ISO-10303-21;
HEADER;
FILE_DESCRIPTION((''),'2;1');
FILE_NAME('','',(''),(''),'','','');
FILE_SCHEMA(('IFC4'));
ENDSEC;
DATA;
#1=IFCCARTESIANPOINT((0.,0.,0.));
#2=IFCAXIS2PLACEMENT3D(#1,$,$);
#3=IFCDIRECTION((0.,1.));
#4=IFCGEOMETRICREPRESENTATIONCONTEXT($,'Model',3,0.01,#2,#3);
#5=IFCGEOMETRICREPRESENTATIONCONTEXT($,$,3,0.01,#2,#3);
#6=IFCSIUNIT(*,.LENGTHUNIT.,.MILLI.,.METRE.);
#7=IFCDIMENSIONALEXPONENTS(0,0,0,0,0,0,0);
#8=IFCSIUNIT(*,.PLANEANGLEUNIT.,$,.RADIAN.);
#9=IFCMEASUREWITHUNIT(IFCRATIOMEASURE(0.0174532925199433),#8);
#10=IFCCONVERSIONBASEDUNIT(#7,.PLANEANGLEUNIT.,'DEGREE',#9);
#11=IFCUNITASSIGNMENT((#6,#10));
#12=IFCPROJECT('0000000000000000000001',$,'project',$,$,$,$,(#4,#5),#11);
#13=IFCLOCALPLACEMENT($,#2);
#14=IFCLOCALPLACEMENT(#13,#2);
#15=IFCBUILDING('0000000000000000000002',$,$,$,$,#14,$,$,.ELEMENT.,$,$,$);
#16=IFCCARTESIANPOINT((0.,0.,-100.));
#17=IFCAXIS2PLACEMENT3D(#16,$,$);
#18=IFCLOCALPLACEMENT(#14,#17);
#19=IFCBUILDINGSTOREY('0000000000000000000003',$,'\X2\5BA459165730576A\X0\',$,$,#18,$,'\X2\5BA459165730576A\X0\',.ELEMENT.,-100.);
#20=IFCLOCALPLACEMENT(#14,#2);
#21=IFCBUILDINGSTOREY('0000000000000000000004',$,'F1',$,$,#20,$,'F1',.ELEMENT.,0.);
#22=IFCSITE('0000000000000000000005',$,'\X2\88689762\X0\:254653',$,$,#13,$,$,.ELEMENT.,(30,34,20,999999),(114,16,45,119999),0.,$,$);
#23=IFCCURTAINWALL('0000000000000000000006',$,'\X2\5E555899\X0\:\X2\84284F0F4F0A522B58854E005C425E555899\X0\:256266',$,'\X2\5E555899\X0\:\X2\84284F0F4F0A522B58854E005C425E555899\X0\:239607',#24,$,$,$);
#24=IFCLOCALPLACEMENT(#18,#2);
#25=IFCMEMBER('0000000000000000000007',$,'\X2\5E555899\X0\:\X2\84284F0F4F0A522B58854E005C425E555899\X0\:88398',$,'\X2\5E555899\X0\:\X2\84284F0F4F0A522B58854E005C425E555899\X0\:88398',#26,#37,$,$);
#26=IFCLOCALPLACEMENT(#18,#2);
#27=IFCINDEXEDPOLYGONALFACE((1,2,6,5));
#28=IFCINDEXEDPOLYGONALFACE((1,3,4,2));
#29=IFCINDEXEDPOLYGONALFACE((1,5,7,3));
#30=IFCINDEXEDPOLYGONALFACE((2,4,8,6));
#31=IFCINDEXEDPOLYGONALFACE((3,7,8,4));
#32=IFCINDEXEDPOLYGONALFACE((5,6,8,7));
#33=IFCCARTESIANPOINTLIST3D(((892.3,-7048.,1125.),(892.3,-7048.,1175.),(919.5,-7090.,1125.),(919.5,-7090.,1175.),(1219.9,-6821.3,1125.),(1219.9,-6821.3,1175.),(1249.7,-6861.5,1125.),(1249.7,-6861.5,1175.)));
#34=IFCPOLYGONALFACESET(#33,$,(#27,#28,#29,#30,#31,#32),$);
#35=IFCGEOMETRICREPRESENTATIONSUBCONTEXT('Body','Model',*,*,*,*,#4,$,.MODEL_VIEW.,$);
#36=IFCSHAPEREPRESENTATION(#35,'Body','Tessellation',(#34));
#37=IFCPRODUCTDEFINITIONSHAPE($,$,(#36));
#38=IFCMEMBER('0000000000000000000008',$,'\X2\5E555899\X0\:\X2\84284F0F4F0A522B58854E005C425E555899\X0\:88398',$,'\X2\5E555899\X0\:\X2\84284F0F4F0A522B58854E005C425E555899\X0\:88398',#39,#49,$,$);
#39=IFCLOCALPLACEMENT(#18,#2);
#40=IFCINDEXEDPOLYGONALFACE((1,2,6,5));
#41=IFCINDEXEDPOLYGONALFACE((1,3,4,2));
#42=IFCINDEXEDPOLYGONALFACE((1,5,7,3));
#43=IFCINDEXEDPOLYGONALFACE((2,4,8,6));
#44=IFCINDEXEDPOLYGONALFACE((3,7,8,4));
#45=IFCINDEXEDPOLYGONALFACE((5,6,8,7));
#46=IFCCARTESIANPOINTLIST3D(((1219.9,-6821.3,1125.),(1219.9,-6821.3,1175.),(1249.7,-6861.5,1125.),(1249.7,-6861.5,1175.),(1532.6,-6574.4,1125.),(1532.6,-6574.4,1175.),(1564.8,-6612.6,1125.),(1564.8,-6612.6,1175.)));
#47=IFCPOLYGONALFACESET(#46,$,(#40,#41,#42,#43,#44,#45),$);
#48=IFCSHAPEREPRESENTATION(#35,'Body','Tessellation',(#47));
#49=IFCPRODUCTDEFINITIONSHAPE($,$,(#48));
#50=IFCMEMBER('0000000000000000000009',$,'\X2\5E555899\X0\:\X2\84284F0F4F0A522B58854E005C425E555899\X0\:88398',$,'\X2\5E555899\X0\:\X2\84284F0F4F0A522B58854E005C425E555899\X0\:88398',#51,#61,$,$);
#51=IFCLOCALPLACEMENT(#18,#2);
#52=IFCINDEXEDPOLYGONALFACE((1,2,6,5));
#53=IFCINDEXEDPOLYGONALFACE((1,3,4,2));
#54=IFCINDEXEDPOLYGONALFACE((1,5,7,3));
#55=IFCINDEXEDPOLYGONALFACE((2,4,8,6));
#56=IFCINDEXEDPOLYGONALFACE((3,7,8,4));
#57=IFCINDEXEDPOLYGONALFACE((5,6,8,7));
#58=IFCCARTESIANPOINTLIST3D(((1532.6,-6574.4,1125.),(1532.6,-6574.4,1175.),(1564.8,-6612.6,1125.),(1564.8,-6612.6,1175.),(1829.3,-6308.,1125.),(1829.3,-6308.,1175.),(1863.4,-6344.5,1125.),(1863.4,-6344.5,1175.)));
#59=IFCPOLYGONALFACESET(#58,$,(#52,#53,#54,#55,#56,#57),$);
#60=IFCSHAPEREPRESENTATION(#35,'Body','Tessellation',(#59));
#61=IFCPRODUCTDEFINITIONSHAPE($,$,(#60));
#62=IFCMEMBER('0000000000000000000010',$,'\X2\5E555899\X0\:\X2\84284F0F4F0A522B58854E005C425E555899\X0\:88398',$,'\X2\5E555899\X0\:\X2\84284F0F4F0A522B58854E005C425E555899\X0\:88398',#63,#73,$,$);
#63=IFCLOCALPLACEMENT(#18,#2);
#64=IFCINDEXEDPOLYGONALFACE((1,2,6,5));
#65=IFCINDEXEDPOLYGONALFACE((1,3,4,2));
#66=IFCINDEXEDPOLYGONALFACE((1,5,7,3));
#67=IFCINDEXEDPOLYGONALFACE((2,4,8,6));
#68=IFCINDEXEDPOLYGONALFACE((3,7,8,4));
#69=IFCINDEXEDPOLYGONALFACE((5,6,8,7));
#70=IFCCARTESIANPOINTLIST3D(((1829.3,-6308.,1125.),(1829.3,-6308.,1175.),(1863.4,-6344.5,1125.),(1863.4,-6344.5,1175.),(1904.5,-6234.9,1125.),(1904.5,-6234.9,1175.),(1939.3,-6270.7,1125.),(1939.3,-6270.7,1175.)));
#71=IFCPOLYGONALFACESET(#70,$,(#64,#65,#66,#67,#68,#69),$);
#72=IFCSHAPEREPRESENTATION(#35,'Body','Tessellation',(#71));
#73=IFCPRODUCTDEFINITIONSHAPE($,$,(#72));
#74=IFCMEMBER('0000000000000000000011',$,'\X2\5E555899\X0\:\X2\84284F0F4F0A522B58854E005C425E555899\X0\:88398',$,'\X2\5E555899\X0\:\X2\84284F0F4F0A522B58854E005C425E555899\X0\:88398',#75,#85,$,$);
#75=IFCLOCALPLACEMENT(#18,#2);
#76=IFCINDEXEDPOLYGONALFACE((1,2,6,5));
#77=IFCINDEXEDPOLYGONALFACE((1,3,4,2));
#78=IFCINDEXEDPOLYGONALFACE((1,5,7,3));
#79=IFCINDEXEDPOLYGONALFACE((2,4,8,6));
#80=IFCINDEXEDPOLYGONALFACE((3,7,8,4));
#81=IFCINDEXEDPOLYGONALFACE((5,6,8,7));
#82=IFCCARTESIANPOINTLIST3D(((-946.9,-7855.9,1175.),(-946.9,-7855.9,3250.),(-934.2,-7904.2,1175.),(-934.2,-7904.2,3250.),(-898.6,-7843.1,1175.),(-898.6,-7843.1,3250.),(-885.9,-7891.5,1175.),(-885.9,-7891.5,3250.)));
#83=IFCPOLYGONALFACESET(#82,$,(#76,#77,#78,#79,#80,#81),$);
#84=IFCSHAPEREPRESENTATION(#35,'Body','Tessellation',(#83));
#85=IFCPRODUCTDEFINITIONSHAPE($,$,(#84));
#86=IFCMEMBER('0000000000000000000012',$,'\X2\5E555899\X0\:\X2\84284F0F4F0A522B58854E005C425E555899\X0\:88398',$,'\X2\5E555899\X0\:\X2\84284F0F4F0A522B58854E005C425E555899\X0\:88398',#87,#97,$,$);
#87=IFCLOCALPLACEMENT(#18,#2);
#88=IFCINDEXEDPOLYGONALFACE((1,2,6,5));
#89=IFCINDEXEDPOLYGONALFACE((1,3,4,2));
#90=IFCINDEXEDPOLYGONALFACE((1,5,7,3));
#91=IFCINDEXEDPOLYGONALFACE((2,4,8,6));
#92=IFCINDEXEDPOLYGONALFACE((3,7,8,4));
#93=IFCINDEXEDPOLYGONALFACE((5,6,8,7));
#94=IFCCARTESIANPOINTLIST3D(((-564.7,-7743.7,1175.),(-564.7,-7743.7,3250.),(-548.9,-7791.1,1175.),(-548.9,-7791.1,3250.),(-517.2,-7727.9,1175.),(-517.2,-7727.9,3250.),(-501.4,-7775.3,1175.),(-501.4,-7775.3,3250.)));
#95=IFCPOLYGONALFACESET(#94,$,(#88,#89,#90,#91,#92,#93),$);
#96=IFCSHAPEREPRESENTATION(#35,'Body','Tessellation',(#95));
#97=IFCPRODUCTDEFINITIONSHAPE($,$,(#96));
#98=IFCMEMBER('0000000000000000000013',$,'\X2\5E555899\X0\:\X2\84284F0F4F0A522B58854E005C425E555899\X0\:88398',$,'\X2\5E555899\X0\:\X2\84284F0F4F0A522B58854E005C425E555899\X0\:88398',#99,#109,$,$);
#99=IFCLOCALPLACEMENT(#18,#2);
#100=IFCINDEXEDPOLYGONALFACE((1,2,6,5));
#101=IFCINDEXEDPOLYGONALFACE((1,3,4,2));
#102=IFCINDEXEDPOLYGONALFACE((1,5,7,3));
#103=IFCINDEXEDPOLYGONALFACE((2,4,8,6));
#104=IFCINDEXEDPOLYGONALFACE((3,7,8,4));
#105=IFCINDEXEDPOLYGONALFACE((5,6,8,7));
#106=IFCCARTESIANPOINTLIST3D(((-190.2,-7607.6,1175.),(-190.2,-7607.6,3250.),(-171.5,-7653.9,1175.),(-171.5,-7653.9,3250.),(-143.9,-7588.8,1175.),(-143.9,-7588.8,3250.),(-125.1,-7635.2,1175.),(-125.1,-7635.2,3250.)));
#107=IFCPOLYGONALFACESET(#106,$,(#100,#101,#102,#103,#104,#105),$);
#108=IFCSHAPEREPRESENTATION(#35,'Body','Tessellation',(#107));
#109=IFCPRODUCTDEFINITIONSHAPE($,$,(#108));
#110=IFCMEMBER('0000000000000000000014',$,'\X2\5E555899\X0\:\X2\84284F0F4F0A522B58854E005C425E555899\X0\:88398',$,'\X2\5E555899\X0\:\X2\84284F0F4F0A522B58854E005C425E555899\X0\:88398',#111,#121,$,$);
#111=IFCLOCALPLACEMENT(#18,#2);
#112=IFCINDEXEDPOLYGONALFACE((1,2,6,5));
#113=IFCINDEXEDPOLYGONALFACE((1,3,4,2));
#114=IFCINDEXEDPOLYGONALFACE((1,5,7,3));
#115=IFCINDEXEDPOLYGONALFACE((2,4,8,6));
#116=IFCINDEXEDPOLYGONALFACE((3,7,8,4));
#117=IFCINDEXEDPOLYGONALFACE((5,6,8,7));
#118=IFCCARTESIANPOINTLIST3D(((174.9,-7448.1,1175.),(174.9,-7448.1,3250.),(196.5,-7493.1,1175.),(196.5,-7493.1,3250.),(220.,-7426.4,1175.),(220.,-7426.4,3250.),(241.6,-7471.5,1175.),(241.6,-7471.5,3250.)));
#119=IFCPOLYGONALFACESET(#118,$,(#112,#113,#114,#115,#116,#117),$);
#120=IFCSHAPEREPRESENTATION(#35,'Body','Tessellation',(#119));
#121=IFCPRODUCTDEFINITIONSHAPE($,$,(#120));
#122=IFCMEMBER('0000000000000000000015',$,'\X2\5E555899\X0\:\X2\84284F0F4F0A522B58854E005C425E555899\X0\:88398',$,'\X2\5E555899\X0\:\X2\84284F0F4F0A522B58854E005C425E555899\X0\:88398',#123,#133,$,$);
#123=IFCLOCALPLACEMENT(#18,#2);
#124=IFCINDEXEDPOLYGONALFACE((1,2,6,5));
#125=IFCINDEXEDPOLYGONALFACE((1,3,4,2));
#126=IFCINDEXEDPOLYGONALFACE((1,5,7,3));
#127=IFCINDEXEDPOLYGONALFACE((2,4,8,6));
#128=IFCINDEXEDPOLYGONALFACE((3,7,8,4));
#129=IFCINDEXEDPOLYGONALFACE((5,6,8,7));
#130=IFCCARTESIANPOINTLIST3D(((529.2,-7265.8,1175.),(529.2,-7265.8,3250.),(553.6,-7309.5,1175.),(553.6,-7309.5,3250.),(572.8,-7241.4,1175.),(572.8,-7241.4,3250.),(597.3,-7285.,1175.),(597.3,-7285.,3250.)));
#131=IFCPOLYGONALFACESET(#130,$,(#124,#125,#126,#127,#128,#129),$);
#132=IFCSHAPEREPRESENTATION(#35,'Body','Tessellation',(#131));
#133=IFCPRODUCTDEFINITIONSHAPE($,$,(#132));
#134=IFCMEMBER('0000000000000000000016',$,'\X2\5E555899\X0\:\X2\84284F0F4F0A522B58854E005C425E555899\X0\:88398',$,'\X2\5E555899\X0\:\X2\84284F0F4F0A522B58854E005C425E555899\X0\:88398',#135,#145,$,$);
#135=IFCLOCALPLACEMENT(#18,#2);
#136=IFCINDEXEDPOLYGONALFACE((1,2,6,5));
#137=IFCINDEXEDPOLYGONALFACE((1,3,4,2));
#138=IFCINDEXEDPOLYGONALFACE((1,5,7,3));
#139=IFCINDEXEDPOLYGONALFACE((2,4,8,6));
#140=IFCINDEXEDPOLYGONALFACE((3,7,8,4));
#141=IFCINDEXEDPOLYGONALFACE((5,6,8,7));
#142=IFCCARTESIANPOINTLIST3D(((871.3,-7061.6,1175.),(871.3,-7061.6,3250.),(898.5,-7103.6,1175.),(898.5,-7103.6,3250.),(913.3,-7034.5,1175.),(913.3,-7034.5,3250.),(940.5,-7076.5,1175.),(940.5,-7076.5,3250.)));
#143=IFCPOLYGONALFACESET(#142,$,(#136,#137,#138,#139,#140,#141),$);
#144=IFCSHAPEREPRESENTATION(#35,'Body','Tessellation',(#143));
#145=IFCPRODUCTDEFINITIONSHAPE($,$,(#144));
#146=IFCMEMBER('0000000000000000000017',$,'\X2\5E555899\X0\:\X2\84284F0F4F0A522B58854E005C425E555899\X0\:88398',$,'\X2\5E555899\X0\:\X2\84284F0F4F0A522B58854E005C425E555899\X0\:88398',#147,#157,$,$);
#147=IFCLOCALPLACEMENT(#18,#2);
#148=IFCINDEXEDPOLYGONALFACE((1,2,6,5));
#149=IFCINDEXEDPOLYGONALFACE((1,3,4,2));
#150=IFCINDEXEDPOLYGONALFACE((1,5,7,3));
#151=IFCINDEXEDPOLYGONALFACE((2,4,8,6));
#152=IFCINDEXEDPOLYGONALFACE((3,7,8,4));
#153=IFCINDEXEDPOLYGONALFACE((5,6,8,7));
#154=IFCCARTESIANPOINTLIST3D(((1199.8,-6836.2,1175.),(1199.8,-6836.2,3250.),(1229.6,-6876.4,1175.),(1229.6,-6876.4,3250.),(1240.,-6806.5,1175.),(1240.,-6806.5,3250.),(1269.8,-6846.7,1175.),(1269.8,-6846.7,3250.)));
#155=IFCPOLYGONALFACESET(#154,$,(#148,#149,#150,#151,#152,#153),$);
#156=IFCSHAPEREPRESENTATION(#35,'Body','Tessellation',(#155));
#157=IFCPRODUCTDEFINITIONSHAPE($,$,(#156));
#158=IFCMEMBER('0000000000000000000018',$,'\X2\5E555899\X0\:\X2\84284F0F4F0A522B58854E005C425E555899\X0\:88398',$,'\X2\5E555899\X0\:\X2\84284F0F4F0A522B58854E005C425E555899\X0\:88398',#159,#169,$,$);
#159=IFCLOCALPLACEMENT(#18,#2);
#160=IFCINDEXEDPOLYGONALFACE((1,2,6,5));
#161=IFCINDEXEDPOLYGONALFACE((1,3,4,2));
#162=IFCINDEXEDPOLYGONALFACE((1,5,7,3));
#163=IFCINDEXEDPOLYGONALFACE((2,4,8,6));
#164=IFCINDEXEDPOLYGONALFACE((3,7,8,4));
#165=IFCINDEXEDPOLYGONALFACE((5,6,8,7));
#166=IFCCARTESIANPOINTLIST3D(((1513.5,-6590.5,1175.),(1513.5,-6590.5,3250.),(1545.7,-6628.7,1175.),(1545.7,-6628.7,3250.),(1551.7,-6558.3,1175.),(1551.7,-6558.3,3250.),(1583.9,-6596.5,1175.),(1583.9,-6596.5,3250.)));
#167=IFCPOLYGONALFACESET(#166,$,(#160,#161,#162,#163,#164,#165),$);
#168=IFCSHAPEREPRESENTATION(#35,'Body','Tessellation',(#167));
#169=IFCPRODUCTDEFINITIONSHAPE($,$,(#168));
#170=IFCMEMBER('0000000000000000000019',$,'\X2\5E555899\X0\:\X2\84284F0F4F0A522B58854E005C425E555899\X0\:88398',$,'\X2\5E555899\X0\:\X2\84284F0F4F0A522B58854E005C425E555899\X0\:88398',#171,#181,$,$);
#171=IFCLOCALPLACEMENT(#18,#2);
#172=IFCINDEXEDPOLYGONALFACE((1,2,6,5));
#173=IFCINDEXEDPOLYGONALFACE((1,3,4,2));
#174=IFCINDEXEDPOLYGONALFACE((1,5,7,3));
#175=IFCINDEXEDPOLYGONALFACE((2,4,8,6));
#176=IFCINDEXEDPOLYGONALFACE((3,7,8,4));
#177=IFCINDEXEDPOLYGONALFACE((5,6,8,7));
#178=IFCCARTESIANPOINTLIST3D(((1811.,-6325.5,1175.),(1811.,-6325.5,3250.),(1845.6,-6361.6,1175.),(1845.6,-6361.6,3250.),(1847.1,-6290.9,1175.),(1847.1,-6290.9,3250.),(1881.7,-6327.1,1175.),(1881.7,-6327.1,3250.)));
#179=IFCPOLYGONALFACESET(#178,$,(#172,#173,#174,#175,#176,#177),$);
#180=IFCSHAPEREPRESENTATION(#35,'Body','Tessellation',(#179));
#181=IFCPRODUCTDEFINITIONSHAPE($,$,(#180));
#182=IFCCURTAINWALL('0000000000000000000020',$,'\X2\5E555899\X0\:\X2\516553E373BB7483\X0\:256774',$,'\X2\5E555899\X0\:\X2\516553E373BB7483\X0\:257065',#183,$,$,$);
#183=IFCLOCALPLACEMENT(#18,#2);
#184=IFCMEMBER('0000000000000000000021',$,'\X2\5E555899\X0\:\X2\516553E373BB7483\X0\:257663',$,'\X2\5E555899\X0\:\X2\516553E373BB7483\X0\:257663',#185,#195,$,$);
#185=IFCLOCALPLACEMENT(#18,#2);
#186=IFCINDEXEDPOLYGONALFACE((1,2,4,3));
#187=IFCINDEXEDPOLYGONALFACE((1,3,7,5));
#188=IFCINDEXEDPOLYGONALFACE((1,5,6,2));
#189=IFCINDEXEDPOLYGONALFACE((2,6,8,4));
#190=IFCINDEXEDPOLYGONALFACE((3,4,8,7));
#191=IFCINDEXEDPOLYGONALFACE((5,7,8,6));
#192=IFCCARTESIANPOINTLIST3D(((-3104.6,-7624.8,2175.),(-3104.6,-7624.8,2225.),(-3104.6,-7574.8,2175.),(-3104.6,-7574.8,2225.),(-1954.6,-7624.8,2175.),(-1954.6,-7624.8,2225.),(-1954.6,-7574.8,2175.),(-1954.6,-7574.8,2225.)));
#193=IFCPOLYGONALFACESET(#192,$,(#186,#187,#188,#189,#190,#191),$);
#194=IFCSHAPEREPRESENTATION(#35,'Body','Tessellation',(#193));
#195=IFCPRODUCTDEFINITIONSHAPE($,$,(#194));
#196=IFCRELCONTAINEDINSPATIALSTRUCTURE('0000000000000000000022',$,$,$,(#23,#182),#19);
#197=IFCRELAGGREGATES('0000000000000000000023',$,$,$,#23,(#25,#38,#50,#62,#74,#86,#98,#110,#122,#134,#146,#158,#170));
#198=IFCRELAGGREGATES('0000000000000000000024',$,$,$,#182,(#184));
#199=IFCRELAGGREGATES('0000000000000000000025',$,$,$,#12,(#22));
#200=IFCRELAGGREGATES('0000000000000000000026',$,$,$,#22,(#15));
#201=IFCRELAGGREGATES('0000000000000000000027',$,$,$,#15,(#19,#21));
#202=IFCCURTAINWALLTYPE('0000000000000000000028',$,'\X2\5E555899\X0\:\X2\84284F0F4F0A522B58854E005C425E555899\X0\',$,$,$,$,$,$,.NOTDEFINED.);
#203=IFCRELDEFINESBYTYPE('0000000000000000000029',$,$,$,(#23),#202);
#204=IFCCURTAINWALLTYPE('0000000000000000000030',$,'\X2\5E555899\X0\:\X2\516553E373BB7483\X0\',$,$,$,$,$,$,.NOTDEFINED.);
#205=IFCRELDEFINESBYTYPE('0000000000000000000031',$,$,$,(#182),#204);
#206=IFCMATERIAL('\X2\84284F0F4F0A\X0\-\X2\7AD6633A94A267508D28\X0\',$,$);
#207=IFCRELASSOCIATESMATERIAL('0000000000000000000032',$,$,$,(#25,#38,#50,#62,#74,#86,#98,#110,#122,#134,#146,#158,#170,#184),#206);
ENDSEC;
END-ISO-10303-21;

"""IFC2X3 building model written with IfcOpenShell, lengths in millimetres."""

from ifc_helpers import new_model, entity, si_unit, converted_unit, direction, frame, frame_2d, origin, origin_2d_with_axis, place, context, subcontext, project, spatial, rectangle, extrude, clip, halfspace, material, type_object, element, aggregate, save


model = new_model("IFC2X3")

# Units and contexts
model_context = context("Model", 3, precision=0.01, world=origin(), true_north=direction((0.0, 1.0)))
context_of_model = context(None, 3, precision=0.01, world=origin(), true_north=direction((0.0, 1.0)))
body_context = subcontext(model_context, "Body", "Model", "MODEL_VIEW")
ifc_project = project(units=[si_unit("LENGTHUNIT", "METRE", prefix="MILLI"), converted_unit("PLANEANGLEUNIT", "DEGREE", entity("IfcRatioMeasure", 0.0174532925199433), si_unit("PLANEANGLEUNIT", "RADIAN"), dimensions=[0, 0, 0, 0, 0, 0, 0])], contexts=[model_context, context_of_model])

# Site, building, storey
site_placement = place(None, origin())
site = spatial("IfcSite", under=ifc_project, at=site_placement, Name="表面:254653", CompositionType="ELEMENT", RefLatitude=(30, 34, 20, 999999), RefLongitude=(114, 16, 45, 119999), RefElevation=0.0)
building_placement = place(site_placement, origin())
building = spatial("IfcBuilding", under=site, at=building_placement, CompositionType="ELEMENT")
storey_1_placement = place(building_placement, frame((0.0, 0.0, -100.0)))
storey_1 = spatial("IfcBuildingStorey", under=building, at=storey_1_placement, Name="室外地坪", LongName="室外地坪", CompositionType="ELEMENT", Elevation=-100.0)

# Curtain walls, members
curtain_wall_type_1 = type_object("IfcCurtainWallType", Name="幕墙:萨伏伊别墅一层幕墙", PredefinedType="NOTDEFINED")
curtain_wall_1_placement = place(storey_1_placement, frame((0.0, 0.0, 100.0)))
curtain_wall_1 = element("IfcCurtainWall", 1, at=curtain_wall_1_placement, inside=storey_1, type_object=curtain_wall_type_1, Name="幕墙:萨伏伊别墅一层幕墙:256266", ObjectType="幕墙:萨伏伊别墅一层幕墙:239607")
ifc_material_1 = material(Name="萨伏伊-竖挺钢材质")
member_1_placement = place(curtain_wall_1_placement, frame((0.0, 0.0, -100.0)))
member_1 = element("IfcMember", 2, at=member_1_placement, material=ifc_material_1, Name="幕墙:萨伏伊别墅一层幕墙:88398", ObjectType="幕墙:萨伏伊别墅一层幕墙:88398", context=body_context, shape_type="Clipping", body=[
    clip(clip(extrude(rectangle(XDim=50.0, YDim=50.0, at=frame_2d((0.0, 0.0), x_axis=(1.0, 0.0))), frame((1235.5, -6841.0, 1150.0), z_axis=(-0.822321, -0.569024, 0.0), x_axis=(0.0, 0.0, -1.0)), (0.0, 0.0, 1.0), 401.6), halfspace(frame((1234.8, -6841.4, 1454.8), z_axis=(0.803942, 0.594708, 0.0), x_axis=(0.594708, -0.803942, 0.0)), False)), halfspace(frame((905.9, -7069.0, 1454.8), z_axis=(-0.83988, -0.542772, 0.0), x_axis=(0.542772, -0.83988, 0.0)), False)),
])
member_2_placement = place(curtain_wall_1_placement, frame((0.0, 0.0, -100.0)))
member_2 = element("IfcMember", 3, at=member_2_placement, material=ifc_material_1, Name="幕墙:萨伏伊别墅一层幕墙:88398", ObjectType="幕墙:萨伏伊别墅一层幕墙:88398", context=body_context, shape_type="Clipping", body=[
    clip(clip(extrude(rectangle(XDim=50.0, YDim=50.0, at=frame_2d((0.0, 0.0), x_axis=(1.0, 0.0))), frame((1549.3, -6593.0, 1150.0), z_axis=(-0.784761, -0.619799, 0.0), x_axis=(0.0, 0.0, -1.0)), (0.0, 0.0, 1.0), 401.6), halfspace(frame((1548.7, -6593.5, 1454.8), z_axis=(0.764797, 0.644272, 0.0), x_axis=(0.644272, -0.764797, 0.0)), False)), halfspace(frame((1234.8, -6841.4, 1454.8), z_axis=(-0.803942, -0.594708, 0.0), x_axis=(0.594708, -0.803942, 0.0)), False)),
])
member_3_placement = place(curtain_wall_1_placement, frame((0.0, 0.0, -100.0)))
member_3 = element("IfcMember", 4, at=member_3_placement, material=ifc_material_1, Name="幕墙:萨伏伊别墅一层幕墙:88398", ObjectType="幕墙:萨伏伊别墅一层幕墙:88398", context=body_context, shape_type="Clipping", body=[
    clip(clip(extrude(rectangle(XDim=50.0, YDim=50.0, at=frame_2d((0.0, 0.0), x_axis=(1.0, 0.0))), frame((1846.7, -6325.9, 1150.0), z_axis=(-0.74407, -0.668102, 0.0), x_axis=(0.0, 0.0, -1.0)), (0.0, 0.0, 1.0), 401.3), halfspace(frame((1846.3, -6326.3, 1454.8), z_axis=(0.730592, 0.682814, 0.0), x_axis=(0.682814, -0.730592, 0.0)), False)), halfspace(frame((1548.7, -6593.5, 1454.8), z_axis=(-0.764797, -0.644272, 0.0), x_axis=(0.644272, -0.764797, 0.0)), False)),
])
member_4_placement = place(curtain_wall_1_placement, frame((0.0, 0.0, -100.0)))
member_4 = element("IfcMember", 5, at=member_4_placement, material=ifc_material_1, Name="幕墙:萨伏伊别墅一层幕墙:88398", ObjectType="幕墙:萨伏伊别墅一层幕墙:88398", context=body_context, shape_type="Clipping", body=[
    clip(extrude(rectangle(XDim=50.0, YDim=50.0, at=frame_2d((0.0, 0.0), x_axis=(1.0, 0.0))), frame((1921.9, -6252.8, 1150.0), z_axis=(-0.716823, -0.697255, 0.0), x_axis=(0.0, 0.0, -1.0)), (0.0, 0.0, 1.0), 105.9), halfspace(frame((1846.3, -6326.3, 1454.8), z_axis=(-0.730592, -0.682814, 0.0), x_axis=(0.682814, -0.730592, 0.0)), False)),
])
member_5_placement = place(curtain_wall_1_placement, frame((0.0, 0.0, -100.0)))
member_5 = element("IfcMember", 6, at=member_5_placement, material=ifc_material_1, Name="幕墙:萨伏伊别墅一层幕墙:88398", ObjectType="幕墙:萨伏伊别墅一层幕墙:88398", context=body_context, shape_type="SweptSolid", body=[
    extrude(rectangle(XDim=50.0, YDim=50.0, at=origin_2d_with_axis()), frame((-916.4, -7873.7, 1175.0), z_axis=(0.0, 0.0, 1.0), x_axis=(0.96693, 0.255043, 0.0)), (0.0, 0.0, 1.0), 2075.0),
])
member_6_placement = place(curtain_wall_1_placement, frame((0.0, 0.0, -100.0)))
member_6 = element("IfcMember", 7, at=member_6_placement, material=ifc_material_1, Name="幕墙:萨伏伊别墅一层幕墙:88398", ObjectType="幕墙:萨伏伊别墅一层幕墙:88398", context=body_context, shape_type="SweptSolid", body=[
    extrude(rectangle(XDim=50.0, YDim=50.0, at=frame_2d((0.0, 0.0), x_axis=(1.0, 0.0))), frame((-533.0, -7759.5, 1175.0), z_axis=(0.0, 0.0, 1.0), x_axis=(0.948901, 0.315573, 0.0)), (0.0, 0.0, 1.0), 2075.0),
])
member_7_placement = place(curtain_wall_1_placement, frame((0.0, 0.0, -100.0)))
member_7 = element("IfcMember", 8, at=member_7_placement, material=ifc_material_1, Name="幕墙:萨伏伊别墅一层幕墙:88398", ObjectType="幕墙:萨伏伊别墅一层幕墙:88398", context=body_context, shape_type="SweptSolid", body=[
    extrude(rectangle(XDim=50.0, YDim=50.0, at=frame_2d((0.0, 0.0), x_axis=(1.0, 0.0))), frame((-157.7, -7621.4, 1175.0), z_axis=(0.0, 0.0, 1.0), x_axis=(0.927088, 0.374844, 0.0)), (0.0, 0.0, 1.0), 2075.0),
])
member_8_placement = place(curtain_wall_1_placement, frame((0.0, 0.0, -100.0)))
member_8 = element("IfcMember", 9, at=member_8_placement, material=ifc_material_1, Name="幕墙:萨伏伊别墅一层幕墙:88398", ObjectType="幕墙:萨伏伊别墅一层幕墙:88398", context=body_context, shape_type="SweptSolid", body=[
    extrude(rectangle(XDim=50.0, YDim=50.0, at=frame_2d((0.0, 0.0), x_axis=(1.0, 0.0))), frame((208.3, -7459.8, 1175.0), z_axis=(0.0, 0.0, 1.0), x_axis=(0.901576, 0.43262, 0.0)), (0.0, 0.0, 1.0), 2075.0),
])
member_9_placement = place(curtain_wall_1_placement, frame((0.0, 0.0, -100.0)))
member_9 = element("IfcMember", 10, at=member_9_placement, material=ifc_material_1, Name="幕墙:萨伏伊别墅一层幕墙:88398", ObjectType="幕墙:萨伏伊别墅一层幕墙:88398", context=body_context, shape_type="SweptSolid", body=[
    extrude(rectangle(XDim=50.0, YDim=50.0, at=frame_2d((0.0, 0.0), x_axis=(1.0, 0.0))), frame((563.2, -7275.4, 1175.0), z_axis=(0.0, 0.0, 1.0), x_axis=(0.872468, 0.488671, 0.0)), (0.0, 0.0, 1.0), 2075.0),
])
member_10_placement = place(curtain_wall_1_placement, frame((0.0, 0.0, -100.0)))
member_10 = element("IfcMember", 11, at=member_10_placement, material=ifc_material_1, Name="幕墙:萨伏伊别墅一层幕墙:88398", ObjectType="幕墙:萨伏伊别墅一层幕墙:88398", context=body_context, shape_type="SweptSolid", body=[
    extrude(rectangle(XDim=50.0, YDim=50.0, at=frame_2d((0.0, 0.0), x_axis=(1.0, 0.0))), frame((905.9, -7069.0, 1175.0), z_axis=(0.0, 0.0, 1.0), x_axis=(0.83988, 0.542772, 0.0)), (0.0, 0.0, 1.0), 2075.0),
])
member_11_placement = place(curtain_wall_1_placement, frame((0.0, 0.0, -100.0)))
member_11 = element("IfcMember", 12, at=member_11_placement, material=ifc_material_1, Name="幕墙:萨伏伊别墅一层幕墙:88398", ObjectType="幕墙:萨伏伊别墅一层幕墙:88398", context=body_context, shape_type="SweptSolid", body=[
    extrude(rectangle(XDim=50.0, YDim=50.0, at=frame_2d((0.0, 0.0), x_axis=(1.0, 0.0))), frame((1234.8, -6841.4, 1175.0), z_axis=(0.0, 0.0, 1.0), x_axis=(0.803942, 0.594708, 0.0)), (0.0, 0.0, 1.0), 2075.0),
])
member_12_placement = place(curtain_wall_1_placement, frame((0.0, 0.0, -100.0)))
member_12 = element("IfcMember", 13, at=member_12_placement, material=ifc_material_1, Name="幕墙:萨伏伊别墅一层幕墙:88398", ObjectType="幕墙:萨伏伊别墅一层幕墙:88398", context=body_context, shape_type="SweptSolid", body=[
    extrude(rectangle(XDim=50.0, YDim=50.0, at=origin_2d_with_axis()), frame((1548.7, -6593.5, 1175.0), z_axis=(0.0, 0.0, 1.0), x_axis=(0.764797, 0.644272, 0.0)), (0.0, 0.0, 1.0), 2075.0),
])
member_13_placement = place(curtain_wall_1_placement, frame((0.0, 0.0, -100.0)))
member_13 = element("IfcMember", 14, at=member_13_placement, material=ifc_material_1, Name="幕墙:萨伏伊别墅一层幕墙:88398", ObjectType="幕墙:萨伏伊别墅一层幕墙:88398", context=body_context, shape_type="SweptSolid", body=[
    extrude(rectangle(XDim=50.0, YDim=50.0, at=origin_2d_with_axis()), frame((1846.3, -6326.3, 1175.0), z_axis=(0.0, 0.0, 1.0), x_axis=(0.722601, 0.691266, 0.0)), (0.0, 0.0, 1.0), 2075.0),
])
aggregate(curtain_wall_1, [member_1, member_2, member_3, member_4, member_5, member_6, member_7, member_8, member_9, member_10, member_11, member_12, member_13])
curtain_wall_type_2 = type_object("IfcCurtainWallType", Name="幕墙:入口玻璃", PredefinedType="NOTDEFINED")
curtain_wall_2_placement = place(storey_1_placement, frame((0.0, 0.0, 100.0)))
curtain_wall_2 = element("IfcCurtainWall", 15, at=curtain_wall_2_placement, inside=storey_1, type_object=curtain_wall_type_2, Name="幕墙:入口玻璃:256774", ObjectType="幕墙:入口玻璃:257065")
member_14_placement = place(curtain_wall_2_placement, frame((0.0, 0.0, -100.0)))
member_14 = element("IfcMember", 16, at=member_14_placement, material=ifc_material_1, Name="幕墙:入口玻璃:257663", ObjectType="幕墙:入口玻璃:257663", context=body_context, shape_type="SweptSolid", body=[
    extrude(rectangle(XDim=50.0, YDim=50.0, at=frame_2d((0.0, 0.0), x_axis=(1.0, 0.0))), frame((-1954.6, -7599.8, 2200.0), z_axis=(-1.0, 0.0, 0.0), x_axis=(0.0, 0.0, -1.0)), (0.0, 0.0, 1.0), 1150.0),
])
aggregate(curtain_wall_2, [member_14])

# Shared definitions
storey_2_placement = place(building_placement, origin())
storey_2 = spatial("IfcBuildingStorey", under=building, at=storey_2_placement, Name="F1", LongName="F1", CompositionType="ELEMENT", Elevation=0.0)

save(model, "model.ifc")
